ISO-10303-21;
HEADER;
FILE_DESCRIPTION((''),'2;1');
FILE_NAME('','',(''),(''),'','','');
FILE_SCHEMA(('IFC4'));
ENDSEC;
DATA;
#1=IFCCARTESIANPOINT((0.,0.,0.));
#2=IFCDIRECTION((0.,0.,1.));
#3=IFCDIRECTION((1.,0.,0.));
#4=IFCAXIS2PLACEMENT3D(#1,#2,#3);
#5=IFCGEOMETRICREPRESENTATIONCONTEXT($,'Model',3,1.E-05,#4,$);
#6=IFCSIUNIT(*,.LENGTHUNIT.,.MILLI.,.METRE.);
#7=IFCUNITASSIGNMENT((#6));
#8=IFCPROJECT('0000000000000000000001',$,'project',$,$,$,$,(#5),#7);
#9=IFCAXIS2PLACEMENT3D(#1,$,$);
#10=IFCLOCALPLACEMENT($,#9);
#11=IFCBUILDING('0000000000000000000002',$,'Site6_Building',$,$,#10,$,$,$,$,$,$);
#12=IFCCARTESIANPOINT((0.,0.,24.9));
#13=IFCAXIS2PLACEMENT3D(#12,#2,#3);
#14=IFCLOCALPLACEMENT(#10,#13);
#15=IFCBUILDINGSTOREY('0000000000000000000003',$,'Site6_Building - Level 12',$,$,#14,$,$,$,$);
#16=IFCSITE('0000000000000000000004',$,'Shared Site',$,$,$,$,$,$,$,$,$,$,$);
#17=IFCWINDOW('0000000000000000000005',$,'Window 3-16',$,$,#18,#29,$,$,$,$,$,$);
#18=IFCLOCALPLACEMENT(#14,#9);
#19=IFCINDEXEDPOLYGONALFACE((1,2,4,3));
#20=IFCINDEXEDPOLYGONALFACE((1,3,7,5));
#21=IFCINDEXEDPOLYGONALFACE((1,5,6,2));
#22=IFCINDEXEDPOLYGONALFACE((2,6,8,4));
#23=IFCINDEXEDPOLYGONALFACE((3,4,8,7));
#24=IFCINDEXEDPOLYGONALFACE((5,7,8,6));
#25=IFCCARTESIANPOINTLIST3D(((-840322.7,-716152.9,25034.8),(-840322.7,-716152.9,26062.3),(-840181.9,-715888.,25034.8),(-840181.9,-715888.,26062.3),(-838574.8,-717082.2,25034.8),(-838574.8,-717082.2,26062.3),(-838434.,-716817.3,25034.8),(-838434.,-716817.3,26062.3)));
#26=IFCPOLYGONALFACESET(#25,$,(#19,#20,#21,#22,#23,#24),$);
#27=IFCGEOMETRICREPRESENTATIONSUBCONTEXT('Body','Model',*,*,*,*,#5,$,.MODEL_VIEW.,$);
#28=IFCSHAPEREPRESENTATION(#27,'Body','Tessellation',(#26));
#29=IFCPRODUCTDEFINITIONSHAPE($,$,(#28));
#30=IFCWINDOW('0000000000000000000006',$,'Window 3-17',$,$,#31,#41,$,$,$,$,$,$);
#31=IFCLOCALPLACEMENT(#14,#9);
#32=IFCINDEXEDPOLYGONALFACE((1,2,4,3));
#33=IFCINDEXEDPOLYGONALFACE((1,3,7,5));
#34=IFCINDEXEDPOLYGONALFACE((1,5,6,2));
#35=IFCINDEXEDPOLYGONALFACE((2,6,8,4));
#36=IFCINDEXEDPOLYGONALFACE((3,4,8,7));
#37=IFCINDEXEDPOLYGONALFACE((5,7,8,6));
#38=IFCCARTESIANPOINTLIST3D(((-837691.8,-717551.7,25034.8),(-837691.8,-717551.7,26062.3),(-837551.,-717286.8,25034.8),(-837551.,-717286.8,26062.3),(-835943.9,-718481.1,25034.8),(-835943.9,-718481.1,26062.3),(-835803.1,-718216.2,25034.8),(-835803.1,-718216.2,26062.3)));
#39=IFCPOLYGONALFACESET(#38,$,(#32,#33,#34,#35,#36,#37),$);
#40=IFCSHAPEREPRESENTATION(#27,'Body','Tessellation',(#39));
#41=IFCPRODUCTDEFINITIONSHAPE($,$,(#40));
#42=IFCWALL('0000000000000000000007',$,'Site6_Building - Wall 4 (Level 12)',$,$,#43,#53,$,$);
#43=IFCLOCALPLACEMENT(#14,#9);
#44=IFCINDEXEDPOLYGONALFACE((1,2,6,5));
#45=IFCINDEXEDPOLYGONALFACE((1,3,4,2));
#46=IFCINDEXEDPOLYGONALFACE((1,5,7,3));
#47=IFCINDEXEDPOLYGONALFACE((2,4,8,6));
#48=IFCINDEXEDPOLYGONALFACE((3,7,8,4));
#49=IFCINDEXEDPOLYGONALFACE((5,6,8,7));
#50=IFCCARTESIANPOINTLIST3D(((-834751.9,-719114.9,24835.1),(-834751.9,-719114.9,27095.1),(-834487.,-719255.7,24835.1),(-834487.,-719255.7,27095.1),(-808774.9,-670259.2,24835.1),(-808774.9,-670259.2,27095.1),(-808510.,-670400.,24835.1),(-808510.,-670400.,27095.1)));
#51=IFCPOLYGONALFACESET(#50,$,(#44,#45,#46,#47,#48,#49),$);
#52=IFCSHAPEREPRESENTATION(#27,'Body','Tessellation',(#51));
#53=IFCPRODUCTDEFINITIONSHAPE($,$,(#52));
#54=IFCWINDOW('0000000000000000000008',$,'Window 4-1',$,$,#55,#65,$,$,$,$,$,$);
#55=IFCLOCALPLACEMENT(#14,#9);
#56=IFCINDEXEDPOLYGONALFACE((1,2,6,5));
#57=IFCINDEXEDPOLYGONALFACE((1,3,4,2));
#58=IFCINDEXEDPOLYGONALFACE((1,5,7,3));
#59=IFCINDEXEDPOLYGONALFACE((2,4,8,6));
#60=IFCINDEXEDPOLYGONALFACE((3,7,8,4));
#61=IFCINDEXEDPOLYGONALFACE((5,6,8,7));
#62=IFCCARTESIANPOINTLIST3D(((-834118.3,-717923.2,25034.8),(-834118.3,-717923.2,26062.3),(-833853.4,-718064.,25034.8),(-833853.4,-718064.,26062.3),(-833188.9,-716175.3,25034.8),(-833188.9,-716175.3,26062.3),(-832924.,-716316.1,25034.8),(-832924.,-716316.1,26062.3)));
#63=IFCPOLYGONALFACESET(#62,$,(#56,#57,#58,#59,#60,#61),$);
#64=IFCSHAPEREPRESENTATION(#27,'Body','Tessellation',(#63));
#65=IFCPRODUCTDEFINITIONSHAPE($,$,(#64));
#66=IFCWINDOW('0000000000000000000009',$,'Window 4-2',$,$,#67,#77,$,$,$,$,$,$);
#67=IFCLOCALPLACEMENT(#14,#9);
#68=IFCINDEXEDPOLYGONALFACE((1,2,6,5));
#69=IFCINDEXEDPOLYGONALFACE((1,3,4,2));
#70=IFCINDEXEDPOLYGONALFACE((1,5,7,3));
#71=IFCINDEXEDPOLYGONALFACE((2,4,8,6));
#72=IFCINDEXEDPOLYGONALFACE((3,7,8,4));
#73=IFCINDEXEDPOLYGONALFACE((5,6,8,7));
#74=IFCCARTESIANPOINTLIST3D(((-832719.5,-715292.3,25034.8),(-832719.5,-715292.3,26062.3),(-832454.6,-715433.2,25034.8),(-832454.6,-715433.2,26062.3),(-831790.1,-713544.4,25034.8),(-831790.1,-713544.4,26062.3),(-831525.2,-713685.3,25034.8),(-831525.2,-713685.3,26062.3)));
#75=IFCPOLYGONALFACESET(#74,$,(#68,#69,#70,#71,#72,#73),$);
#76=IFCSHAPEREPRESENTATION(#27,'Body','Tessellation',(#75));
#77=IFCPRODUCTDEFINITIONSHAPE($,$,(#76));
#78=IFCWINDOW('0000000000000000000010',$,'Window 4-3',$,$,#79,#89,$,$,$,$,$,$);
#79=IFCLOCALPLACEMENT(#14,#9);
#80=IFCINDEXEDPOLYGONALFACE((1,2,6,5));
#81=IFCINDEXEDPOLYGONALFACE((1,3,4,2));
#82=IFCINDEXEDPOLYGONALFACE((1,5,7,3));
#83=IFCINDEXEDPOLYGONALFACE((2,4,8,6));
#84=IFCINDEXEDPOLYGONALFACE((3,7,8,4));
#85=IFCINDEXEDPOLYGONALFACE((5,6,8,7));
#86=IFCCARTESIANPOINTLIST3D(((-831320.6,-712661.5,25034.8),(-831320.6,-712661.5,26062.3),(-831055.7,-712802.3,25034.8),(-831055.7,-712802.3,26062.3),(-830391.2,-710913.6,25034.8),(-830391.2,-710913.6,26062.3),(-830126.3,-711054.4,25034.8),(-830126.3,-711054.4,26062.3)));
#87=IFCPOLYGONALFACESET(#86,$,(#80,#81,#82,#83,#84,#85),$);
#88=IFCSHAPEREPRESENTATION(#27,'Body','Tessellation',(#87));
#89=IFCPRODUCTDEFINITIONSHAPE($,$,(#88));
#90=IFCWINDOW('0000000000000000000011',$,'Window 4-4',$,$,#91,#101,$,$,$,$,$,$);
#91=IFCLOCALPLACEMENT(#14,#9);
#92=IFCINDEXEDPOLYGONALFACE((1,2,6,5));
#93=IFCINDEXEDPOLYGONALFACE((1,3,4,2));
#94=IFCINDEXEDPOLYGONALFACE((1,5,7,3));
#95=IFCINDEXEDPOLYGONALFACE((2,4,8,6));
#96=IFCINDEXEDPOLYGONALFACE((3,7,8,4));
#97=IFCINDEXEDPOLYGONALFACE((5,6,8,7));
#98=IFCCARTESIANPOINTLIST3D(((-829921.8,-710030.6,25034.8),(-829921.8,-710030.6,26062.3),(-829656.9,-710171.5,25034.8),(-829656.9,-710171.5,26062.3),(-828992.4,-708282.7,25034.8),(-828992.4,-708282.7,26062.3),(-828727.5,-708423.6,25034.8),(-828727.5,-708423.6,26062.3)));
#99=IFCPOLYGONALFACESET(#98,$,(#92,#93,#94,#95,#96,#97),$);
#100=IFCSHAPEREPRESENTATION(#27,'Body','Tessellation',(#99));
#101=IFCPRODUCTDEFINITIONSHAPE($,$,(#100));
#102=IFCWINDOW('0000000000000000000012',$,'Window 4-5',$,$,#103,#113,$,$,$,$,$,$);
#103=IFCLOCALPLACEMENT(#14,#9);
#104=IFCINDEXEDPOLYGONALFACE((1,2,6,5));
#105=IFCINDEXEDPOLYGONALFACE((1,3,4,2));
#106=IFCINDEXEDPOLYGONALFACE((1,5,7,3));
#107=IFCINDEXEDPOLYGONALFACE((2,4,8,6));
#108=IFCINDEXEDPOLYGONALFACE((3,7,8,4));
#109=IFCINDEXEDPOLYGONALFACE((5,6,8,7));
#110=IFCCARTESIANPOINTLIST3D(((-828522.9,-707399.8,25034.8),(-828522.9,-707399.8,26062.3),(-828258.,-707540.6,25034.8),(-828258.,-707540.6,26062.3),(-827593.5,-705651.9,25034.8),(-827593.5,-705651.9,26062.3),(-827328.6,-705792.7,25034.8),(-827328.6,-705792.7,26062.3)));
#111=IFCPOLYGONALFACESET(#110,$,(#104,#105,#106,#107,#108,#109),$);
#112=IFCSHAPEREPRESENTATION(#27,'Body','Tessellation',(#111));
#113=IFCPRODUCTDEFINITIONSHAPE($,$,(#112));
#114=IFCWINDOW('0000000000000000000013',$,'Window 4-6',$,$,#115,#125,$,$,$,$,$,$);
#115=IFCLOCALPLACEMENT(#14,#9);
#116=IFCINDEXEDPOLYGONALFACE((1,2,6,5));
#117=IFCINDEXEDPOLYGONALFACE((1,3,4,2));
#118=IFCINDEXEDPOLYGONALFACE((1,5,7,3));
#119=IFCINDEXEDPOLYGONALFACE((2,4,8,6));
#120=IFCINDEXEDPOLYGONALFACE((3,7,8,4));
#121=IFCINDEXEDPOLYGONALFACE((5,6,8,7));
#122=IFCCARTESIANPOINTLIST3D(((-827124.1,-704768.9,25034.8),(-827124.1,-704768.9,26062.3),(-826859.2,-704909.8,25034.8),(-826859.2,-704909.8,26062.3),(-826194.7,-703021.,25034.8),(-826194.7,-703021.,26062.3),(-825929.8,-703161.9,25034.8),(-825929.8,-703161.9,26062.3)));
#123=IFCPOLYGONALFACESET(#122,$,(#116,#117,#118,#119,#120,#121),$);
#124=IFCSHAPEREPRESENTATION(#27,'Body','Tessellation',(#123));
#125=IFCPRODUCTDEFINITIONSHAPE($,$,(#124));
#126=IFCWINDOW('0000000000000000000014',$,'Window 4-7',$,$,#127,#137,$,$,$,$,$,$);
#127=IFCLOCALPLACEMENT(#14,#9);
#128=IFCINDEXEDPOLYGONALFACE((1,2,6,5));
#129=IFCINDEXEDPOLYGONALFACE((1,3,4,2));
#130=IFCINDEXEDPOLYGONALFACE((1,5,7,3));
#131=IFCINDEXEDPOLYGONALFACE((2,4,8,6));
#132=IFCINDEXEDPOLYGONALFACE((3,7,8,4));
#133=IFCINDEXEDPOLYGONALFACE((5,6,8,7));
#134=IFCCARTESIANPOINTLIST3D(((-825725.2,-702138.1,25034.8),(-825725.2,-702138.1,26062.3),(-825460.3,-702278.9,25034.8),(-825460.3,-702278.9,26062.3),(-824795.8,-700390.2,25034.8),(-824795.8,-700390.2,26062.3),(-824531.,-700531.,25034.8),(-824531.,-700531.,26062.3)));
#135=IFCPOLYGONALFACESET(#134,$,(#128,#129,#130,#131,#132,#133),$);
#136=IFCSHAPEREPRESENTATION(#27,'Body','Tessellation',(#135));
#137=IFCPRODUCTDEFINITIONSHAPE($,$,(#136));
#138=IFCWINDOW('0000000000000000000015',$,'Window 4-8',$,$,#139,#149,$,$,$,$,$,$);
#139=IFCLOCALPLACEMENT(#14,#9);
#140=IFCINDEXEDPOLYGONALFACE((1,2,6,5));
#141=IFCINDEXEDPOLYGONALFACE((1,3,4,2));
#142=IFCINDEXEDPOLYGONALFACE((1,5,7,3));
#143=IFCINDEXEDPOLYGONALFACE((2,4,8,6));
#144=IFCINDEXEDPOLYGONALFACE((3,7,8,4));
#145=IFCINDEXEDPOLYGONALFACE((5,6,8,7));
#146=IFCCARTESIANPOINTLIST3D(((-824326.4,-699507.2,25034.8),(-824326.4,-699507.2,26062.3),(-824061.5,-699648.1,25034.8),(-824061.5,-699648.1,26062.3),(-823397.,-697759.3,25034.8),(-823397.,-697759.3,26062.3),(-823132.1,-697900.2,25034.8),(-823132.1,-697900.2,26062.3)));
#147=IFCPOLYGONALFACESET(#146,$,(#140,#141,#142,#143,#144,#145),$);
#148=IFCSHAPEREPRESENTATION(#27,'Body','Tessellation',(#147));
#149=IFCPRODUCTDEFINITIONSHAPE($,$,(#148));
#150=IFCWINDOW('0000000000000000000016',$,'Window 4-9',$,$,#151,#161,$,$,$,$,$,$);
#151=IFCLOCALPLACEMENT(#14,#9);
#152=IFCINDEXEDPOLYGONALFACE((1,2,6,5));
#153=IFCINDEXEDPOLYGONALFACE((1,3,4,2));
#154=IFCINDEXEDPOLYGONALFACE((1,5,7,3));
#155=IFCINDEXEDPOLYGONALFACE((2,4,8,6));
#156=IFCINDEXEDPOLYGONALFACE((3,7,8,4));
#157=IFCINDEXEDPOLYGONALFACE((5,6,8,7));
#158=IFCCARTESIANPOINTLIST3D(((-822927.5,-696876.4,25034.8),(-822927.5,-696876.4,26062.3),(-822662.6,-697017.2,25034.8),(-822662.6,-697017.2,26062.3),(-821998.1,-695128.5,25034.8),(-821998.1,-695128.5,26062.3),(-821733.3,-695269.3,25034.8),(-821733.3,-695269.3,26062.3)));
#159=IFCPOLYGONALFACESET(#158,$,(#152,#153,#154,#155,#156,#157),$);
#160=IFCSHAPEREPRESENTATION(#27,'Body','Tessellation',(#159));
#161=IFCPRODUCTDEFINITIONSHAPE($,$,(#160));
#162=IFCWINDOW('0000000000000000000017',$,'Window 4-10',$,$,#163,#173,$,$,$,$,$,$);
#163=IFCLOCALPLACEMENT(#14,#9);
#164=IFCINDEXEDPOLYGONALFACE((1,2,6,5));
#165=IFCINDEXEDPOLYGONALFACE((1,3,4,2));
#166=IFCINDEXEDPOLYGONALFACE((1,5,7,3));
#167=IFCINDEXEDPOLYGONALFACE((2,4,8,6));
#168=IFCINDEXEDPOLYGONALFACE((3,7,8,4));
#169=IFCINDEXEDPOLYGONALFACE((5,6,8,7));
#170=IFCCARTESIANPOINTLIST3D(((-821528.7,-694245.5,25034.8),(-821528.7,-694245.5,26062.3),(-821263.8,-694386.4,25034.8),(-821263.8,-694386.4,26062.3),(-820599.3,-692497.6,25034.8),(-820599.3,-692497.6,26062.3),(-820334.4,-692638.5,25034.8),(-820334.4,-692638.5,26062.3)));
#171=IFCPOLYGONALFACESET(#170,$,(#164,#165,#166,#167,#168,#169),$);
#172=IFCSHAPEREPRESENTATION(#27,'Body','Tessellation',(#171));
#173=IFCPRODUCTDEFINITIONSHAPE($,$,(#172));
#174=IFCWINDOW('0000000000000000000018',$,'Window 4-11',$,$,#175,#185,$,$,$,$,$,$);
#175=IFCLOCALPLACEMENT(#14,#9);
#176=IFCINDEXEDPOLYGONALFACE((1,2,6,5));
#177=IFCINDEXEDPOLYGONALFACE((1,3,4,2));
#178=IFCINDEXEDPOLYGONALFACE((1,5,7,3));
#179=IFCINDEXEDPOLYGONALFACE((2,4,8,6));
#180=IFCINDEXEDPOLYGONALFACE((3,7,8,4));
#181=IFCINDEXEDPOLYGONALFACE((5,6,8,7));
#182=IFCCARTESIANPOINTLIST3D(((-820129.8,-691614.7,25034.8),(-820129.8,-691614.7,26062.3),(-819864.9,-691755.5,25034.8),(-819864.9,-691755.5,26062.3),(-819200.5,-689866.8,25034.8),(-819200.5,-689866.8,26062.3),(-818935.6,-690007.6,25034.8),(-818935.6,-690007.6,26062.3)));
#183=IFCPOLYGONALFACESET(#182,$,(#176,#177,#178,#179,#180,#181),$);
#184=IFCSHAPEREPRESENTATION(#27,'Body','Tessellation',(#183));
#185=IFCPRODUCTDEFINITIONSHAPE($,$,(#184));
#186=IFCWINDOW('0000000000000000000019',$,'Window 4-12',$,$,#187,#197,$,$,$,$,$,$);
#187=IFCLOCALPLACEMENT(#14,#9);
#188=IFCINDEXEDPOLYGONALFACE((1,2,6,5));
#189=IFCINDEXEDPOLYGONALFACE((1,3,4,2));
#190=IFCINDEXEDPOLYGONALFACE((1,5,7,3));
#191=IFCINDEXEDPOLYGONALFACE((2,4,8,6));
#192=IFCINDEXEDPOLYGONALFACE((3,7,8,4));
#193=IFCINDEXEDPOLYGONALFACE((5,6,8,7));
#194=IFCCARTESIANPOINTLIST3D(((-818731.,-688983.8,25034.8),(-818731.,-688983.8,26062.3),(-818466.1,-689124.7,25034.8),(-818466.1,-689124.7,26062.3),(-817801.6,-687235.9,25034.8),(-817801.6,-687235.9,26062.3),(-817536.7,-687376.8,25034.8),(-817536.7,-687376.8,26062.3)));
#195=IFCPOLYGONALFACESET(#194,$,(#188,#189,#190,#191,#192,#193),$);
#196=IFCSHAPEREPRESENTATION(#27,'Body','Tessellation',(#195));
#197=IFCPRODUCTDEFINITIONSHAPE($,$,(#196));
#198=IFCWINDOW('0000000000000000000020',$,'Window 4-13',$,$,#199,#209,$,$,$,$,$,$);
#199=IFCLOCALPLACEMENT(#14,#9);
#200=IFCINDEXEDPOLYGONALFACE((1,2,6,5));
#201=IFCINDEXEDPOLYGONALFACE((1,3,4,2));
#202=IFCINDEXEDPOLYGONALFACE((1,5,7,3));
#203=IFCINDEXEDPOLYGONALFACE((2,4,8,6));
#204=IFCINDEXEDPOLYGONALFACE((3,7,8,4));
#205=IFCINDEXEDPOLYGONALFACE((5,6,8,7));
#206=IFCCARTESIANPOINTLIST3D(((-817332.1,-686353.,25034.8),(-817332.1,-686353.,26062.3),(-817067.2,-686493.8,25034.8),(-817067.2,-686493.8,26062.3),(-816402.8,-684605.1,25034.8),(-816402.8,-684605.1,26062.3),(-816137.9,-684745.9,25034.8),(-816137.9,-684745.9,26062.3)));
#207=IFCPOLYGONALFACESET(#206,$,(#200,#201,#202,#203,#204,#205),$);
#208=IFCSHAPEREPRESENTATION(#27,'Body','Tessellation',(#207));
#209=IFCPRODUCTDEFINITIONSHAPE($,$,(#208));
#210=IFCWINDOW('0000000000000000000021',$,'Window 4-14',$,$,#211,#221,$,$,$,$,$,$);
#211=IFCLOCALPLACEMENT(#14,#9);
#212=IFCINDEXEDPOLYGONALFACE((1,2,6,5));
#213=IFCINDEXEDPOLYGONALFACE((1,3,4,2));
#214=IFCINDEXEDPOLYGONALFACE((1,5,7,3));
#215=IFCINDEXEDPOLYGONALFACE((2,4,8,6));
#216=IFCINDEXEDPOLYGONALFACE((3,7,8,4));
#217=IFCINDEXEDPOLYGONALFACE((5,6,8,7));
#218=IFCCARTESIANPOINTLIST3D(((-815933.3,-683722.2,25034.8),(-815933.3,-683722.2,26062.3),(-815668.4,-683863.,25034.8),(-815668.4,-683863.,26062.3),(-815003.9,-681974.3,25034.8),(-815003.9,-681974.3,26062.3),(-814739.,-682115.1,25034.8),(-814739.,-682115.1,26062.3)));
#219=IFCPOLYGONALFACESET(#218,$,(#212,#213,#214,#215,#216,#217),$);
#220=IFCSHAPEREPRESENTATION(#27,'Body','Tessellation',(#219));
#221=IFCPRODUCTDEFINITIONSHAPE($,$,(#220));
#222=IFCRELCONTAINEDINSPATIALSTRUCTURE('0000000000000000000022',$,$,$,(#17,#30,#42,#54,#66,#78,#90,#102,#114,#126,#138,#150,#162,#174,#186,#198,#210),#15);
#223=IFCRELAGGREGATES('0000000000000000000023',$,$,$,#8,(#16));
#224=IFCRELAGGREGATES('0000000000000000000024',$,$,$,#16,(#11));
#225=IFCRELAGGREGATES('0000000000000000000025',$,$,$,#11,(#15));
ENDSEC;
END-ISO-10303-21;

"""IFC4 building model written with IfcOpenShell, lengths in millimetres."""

from ifc_helpers import new_model, si_unit, frame, origin, origin_with_axes, place, context, subcontext, project, spatial, indexed_curve, outline, extrude, element, save


model = new_model("IFC4")

# Units and contexts
model_context = context("Model", 3, precision=1e-05, world=origin_with_axes())
body_context = subcontext(model_context, "Body", "Model", "MODEL_VIEW")
ifc_project = project(units=[si_unit("LENGTHUNIT", "METRE", prefix="MILLI")], contexts=[model_context])

# Site, building, storey
site = spatial("IfcSite", under=ifc_project, Name="Shared Site")
building_placement = place(None, origin())
building = spatial("IfcBuilding", under=site, at=building_placement, Name="Site6_Building")
storey_placement = place(building_placement, frame((0.0, 0.0, 24.9), z_axis=(0.0, 0.0, 1.0), x_axis=(1.0, 0.0, 0.0)))
storey = spatial("IfcBuildingStorey", under=building, at=storey_placement, Name="Site6_Building - Level 12")

# Windows
for number, where, z_axis, x_axis, name in (
    (1, (-840322.7, -716152.9, 25034.8), (0.0, 0.0, 1.0), (0.882948, -0.469472, 0.0), "Window 3-16"),
    (2, (-837691.8, -717551.7, 25034.8), (0.0, 0.0, 1.0), (0.882948, -0.469472, 0.0), "Window 3-17"),
):
    element("IfcWindow", number, at=place(storey_placement, frame(where, z_axis=z_axis, x_axis=x_axis)), inside=storey, Name=name, context=body_context, shape_type="SweptSolid", body=[
        extrude(outline(indexed_curve([(0.0, 0.0), (0.0, 300.0), (1979.6, 300.0), (1979.6, 0.0), (0.0, 0.0)], self_intersect=False)), origin_with_axes(), (0.0, 0.0, 1.0), 1027.5),
    ])

# Wall
wall_1_placement = place(storey_placement, frame((-834487.0, -719255.7, 24835.1), z_axis=(0.0, 0.0, 1.0), x_axis=(0.469472, 0.882948, 0.0)))
element("IfcWall", 3, at=wall_1_placement, inside=storey, Name="Site6_Building - Wall 4 (Level 12)", context=body_context, shape_type="SweptSolid", body=[
    extrude(outline(indexed_curve([(0.0, 0.0), (0.0, 300.0), (55332.5, 300.0), (55332.5, 0.0), (0.0, 0.0)], self_intersect=False)), origin_with_axes(), (0.0, 0.0, 1.0), 2260.0),
])

# Windows
for number, where, z_axis, x_axis, name in (
    (4, (-833853.4, -718064.0, 25034.8), (0.0, 0.0, 1.0), (0.469472, 0.882948, 0.0), "Window 4-1"),
    (5, (-832454.6, -715433.2, 25034.8), (0.0, 0.0, 1.0), (0.469472, 0.882948, 0.0), "Window 4-2"),
    (6, (-831055.7, -712802.3, 25034.8), (0.0, 0.0, 1.0), (0.469472, 0.882948, 0.0), "Window 4-3"),
    (7, (-829656.9, -710171.5, 25034.8), (0.0, 0.0, 1.0), (0.469472, 0.882948, 0.0), "Window 4-4"),
    (8, (-828258.0, -707540.6, 25034.8), (0.0, 0.0, 1.0), (0.469472, 0.882948, 0.0), "Window 4-5"),
    (9, (-826859.2, -704909.8, 25034.8), (0.0, 0.0, 1.0), (0.469472, 0.882948, 0.0), "Window 4-6"),
    (10, (-825460.3, -702278.9, 25034.8), (0.0, 0.0, 1.0), (0.469472, 0.882948, 0.0), "Window 4-7"),
    (11, (-824061.5, -699648.1, 25034.8), (0.0, 0.0, 1.0), (0.469472, 0.882948, 0.0), "Window 4-8"),
    (12, (-822662.6, -697017.2, 25034.8), (0.0, 0.0, 1.0), (0.469472, 0.882948, 0.0), "Window 4-9"),
    (13, (-821263.8, -694386.4, 25034.8), (0.0, 0.0, 1.0), (0.469472, 0.882948, 0.0), "Window 4-10"),
    (14, (-819864.9, -691755.5, 25034.8), (0.0, 0.0, 1.0), (0.469472, 0.882948, 0.0), "Window 4-11"),
    (15, (-818466.1, -689124.7, 25034.8), (0.0, 0.0, 1.0), (0.469472, 0.882948, 0.0), "Window 4-12"),
    (16, (-817067.2, -686493.8, 25034.8), (0.0, 0.0, 1.0), (0.469472, 0.882948, 0.0), "Window 4-13"),
    (17, (-815668.4, -683863.0, 25034.8), (0.0, 0.0, 1.0), (0.469472, 0.882948, 0.0), "Window 4-14"),
):
    element("IfcWindow", number, at=place(storey_placement, frame(where, z_axis=z_axis, x_axis=x_axis)), inside=storey, Name=name, context=body_context, shape_type="SweptSolid", body=[
        extrude(outline(indexed_curve([(0.0, 0.0), (0.0, 300.0), (1979.6, 300.0), (1979.6, 0.0), (0.0, 0.0)], self_intersect=False)), origin_with_axes(), (0.0, 0.0, 1.0), 1027.5),
    ])

save(model, "model.ifc")
